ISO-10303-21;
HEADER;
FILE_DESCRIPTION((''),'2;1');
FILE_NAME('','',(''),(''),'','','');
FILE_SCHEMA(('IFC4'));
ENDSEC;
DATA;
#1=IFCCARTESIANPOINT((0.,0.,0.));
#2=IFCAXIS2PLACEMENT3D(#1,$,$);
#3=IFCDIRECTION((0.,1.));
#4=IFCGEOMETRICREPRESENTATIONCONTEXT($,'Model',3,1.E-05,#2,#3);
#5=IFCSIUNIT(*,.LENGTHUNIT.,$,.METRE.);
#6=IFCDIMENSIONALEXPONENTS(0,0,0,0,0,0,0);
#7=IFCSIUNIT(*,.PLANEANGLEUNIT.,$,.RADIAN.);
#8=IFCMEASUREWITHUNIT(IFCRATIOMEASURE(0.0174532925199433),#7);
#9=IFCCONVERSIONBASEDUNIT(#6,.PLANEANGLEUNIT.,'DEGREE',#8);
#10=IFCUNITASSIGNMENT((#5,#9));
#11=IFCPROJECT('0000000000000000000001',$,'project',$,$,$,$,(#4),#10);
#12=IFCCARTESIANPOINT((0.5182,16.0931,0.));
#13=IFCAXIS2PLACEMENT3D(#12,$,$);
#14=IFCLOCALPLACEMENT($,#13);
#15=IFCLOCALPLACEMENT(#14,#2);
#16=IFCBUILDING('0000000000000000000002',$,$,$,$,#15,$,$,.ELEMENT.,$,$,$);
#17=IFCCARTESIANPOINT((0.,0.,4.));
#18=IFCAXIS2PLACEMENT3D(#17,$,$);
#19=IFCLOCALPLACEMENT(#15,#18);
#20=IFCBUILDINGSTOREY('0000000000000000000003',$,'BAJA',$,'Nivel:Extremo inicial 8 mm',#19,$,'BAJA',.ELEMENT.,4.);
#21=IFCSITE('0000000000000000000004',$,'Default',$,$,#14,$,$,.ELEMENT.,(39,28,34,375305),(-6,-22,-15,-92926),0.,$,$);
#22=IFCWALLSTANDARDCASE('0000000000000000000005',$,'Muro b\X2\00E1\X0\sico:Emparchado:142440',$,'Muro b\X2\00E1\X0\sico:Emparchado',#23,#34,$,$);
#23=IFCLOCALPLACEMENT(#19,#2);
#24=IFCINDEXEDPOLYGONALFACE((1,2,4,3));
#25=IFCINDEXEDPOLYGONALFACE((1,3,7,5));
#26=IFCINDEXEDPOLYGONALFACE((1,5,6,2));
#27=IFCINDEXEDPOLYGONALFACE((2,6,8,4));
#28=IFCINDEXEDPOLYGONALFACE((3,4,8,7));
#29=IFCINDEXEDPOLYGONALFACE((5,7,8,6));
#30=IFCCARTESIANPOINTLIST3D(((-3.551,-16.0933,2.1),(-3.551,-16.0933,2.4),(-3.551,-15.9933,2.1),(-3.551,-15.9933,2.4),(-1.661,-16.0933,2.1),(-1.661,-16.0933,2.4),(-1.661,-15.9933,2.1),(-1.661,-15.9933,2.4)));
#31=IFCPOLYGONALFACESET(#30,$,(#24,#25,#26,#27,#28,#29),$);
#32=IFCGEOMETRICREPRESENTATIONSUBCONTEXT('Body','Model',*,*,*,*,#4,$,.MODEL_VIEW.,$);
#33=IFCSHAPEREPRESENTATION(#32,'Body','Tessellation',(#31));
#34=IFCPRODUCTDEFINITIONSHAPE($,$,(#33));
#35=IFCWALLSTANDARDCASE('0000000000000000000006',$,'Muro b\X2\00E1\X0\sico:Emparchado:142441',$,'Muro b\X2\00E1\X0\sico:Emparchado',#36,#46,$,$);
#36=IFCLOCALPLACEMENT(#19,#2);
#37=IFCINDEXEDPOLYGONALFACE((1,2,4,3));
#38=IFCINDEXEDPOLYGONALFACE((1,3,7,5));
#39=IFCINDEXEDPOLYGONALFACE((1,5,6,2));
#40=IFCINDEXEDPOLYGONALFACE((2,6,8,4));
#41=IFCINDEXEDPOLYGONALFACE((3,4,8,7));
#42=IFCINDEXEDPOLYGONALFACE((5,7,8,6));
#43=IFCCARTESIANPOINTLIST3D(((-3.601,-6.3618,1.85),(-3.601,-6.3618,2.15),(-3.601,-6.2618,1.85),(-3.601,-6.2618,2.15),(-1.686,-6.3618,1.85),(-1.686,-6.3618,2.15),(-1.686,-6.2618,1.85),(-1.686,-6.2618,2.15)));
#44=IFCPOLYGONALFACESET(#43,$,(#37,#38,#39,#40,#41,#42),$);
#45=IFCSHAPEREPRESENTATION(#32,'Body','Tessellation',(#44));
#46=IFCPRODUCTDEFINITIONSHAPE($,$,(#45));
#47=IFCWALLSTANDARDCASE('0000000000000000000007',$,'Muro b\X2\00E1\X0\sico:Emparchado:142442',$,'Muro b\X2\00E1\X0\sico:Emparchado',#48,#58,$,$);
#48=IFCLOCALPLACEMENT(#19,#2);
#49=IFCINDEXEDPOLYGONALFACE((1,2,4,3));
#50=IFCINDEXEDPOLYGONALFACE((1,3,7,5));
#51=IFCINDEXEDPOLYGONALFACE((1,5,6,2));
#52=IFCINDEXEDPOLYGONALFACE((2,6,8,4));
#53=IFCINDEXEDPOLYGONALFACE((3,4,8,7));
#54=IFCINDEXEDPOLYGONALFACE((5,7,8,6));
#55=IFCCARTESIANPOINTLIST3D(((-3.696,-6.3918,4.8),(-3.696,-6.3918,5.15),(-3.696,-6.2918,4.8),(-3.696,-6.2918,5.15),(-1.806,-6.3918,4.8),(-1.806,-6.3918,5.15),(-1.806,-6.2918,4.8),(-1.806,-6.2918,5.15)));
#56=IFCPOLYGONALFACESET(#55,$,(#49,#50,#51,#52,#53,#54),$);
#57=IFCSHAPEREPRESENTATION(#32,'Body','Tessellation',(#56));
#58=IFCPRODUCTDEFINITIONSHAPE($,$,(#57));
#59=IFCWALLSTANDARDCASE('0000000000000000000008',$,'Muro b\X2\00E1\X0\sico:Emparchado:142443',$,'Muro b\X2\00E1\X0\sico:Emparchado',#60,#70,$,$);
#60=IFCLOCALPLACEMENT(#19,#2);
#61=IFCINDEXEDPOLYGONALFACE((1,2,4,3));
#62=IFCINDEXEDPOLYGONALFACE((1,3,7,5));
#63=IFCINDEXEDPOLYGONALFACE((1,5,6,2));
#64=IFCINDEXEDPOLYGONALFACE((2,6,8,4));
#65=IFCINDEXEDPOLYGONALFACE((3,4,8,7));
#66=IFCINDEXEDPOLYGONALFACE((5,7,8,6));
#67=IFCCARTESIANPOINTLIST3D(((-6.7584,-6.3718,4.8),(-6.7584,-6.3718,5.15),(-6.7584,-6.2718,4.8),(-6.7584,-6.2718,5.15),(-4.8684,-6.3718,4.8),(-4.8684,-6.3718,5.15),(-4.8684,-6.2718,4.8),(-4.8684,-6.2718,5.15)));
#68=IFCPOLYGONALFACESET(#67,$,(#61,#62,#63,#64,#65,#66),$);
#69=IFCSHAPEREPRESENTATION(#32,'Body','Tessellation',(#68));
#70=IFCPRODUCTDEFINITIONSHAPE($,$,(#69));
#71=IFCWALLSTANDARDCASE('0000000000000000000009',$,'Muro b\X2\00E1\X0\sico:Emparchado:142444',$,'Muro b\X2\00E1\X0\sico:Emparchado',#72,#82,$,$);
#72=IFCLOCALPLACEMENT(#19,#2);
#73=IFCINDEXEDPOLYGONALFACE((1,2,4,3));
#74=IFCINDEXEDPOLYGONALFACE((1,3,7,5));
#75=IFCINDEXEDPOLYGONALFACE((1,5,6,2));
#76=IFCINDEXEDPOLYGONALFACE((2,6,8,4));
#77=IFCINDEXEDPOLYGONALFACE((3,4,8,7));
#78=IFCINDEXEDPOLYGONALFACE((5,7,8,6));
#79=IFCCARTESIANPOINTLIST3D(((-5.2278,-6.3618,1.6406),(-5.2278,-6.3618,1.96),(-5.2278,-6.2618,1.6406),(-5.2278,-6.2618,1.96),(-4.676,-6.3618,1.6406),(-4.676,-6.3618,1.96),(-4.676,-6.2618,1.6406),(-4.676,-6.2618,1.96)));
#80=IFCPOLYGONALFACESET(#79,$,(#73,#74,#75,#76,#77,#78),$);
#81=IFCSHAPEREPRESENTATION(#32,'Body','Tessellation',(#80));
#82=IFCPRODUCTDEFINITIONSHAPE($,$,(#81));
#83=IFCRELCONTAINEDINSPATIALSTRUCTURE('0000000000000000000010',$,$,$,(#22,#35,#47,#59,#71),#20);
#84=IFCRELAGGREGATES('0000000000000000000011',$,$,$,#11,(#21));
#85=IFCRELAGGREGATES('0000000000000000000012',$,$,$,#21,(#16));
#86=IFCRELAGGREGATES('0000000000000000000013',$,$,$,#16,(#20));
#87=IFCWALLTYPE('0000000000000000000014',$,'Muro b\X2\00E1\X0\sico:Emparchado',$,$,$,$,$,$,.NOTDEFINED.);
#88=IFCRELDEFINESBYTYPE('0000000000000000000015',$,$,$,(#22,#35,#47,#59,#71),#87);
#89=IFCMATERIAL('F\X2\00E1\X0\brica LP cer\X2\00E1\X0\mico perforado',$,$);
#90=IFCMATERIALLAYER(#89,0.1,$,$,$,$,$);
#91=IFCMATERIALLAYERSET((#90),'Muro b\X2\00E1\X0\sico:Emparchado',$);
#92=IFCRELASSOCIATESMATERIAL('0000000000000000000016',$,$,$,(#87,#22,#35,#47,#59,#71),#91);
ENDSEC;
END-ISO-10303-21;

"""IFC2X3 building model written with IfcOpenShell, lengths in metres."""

from ifc_helpers import new_model, entity, si_unit, converted_unit, direction, frame, frame_2d, origin, place, context, subcontext, project, spatial, rectangle, extrude, material, layer, layer_set, layer_usage, type_object, element, save


model = new_model("IFC2X3")

# Units and contexts
model_context = context("Model", 3, precision=1e-05, world=origin(), true_north=direction((0.0, 1.0)))
body_context = subcontext(model_context, "Body", "Model", "MODEL_VIEW")
ifc_project = project(units=[si_unit("LENGTHUNIT", "METRE"), converted_unit("PLANEANGLEUNIT", "DEGREE", entity("IfcRatioMeasure", 0.0174532925199433), si_unit("PLANEANGLEUNIT", "RADIAN"), dimensions=[0, 0, 0, 0, 0, 0, 0])], contexts=[model_context])

# Site, building, storey
site_placement = place(None, frame((0.5182, 16.0931, 0.0)))
site = spatial("IfcSite", under=ifc_project, at=site_placement, Name="Default", CompositionType="ELEMENT", RefLatitude=(39, 28, 34, 375305), RefLongitude=(-6, -22, -15, -92926), RefElevation=0.0)
building_placement = place(site_placement, origin())
building = spatial("IfcBuilding", under=site, at=building_placement, CompositionType="ELEMENT")
storey_placement = place(building_placement, frame((0.0, 0.0, 4.0)))
storey = spatial("IfcBuildingStorey", under=building, at=storey_placement, Name="BAJA", ObjectType="Nivel:Extremo inicial 8 mm", LongName="BAJA", CompositionType="ELEMENT", Elevation=4.0)

# Shared definitions
ifc_material_1 = material(Name="Fábrica LP cerámico perforado")

# Walls
ifc_layer_1 = layer(ifc_material_1, 0.1)
ifc_layer_set_1 = layer_set([ifc_layer_1], Name="Muro básico:Emparchado")
wall_type_1 = type_object("IfcWallType", Name="Muro básico:Emparchado", PredefinedType="NOTDEFINED", material=ifc_layer_set_1)
ifc_layer_usage_1 = layer_usage(ifc_layer_set_1, "AXIS2", "NEGATIVE", 0.05)
wall_1_placement = place(storey_placement, frame((-3.551, -16.0433, 2.1)))
element("IfcWallStandardCase", 1, at=wall_1_placement, inside=storey, type_object=wall_type_1, material=ifc_layer_usage_1, Name="Muro básico:Emparchado:142440", ObjectType="Muro básico:Emparchado", context=body_context, shape_type="SweptSolid", body=[
    extrude(rectangle(XDim=1.89, YDim=0.1, at=frame_2d((0.945, 0.0), x_axis=(-1.0, 0.0))), origin(), (0.0, 0.0, 1.0), 0.3),
])
ifc_layer_usage_2 = layer_usage(ifc_layer_set_1, "AXIS2", "NEGATIVE", 0.05)
wall_2_placement = place(storey_placement, frame((-3.601, -6.3118, 1.85)))
element("IfcWallStandardCase", 2, at=wall_2_placement, inside=storey, type_object=wall_type_1, material=ifc_layer_usage_2, Name="Muro básico:Emparchado:142441", ObjectType="Muro básico:Emparchado", context=body_context, shape_type="SweptSolid", body=[
    extrude(rectangle(XDim=1.9151, YDim=0.1, at=frame_2d((0.9575, 0.0), x_axis=(-1.0, 0.0))), origin(), (0.0, 0.0, 1.0), 0.3),
])
ifc_layer_usage_3 = layer_usage(ifc_layer_set_1, "AXIS2", "NEGATIVE", 0.05)
wall_3_placement = place(storey_placement, frame((-3.696, -6.3418, 4.8)))
element("IfcWallStandardCase", 3, at=wall_3_placement, inside=storey, type_object=wall_type_1, material=ifc_layer_usage_3, Name="Muro básico:Emparchado:142442", ObjectType="Muro básico:Emparchado", context=body_context, shape_type="SweptSolid", body=[
    extrude(rectangle(XDim=1.89, YDim=0.1, at=frame_2d((0.945, 0.0), x_axis=(-1.0, 0.0))), origin(), (0.0, 0.0, 1.0), 0.35),
])
ifc_layer_usage_4 = layer_usage(ifc_layer_set_1, "AXIS2", "NEGATIVE", 0.05)
wall_4_placement = place(storey_placement, frame((-6.7584, -6.3218, 4.8)))
element("IfcWallStandardCase", 4, at=wall_4_placement, inside=storey, type_object=wall_type_1, material=ifc_layer_usage_4, Name="Muro básico:Emparchado:142443", ObjectType="Muro básico:Emparchado", context=body_context, shape_type="SweptSolid", body=[
    extrude(rectangle(XDim=1.89, YDim=0.1, at=frame_2d((0.945, 0.0), x_axis=(-1.0, 0.0))), origin(), (0.0, 0.0, 1.0), 0.35),
])
ifc_layer_usage_5 = layer_usage(ifc_layer_set_1, "AXIS2", "NEGATIVE", 0.05)
wall_5_placement = place(storey_placement, frame((-5.2278, -6.3118, 1.6406)))
element("IfcWallStandardCase", 5, at=wall_5_placement, inside=storey, type_object=wall_type_1, material=ifc_layer_usage_5, Name="Muro básico:Emparchado:142444", ObjectType="Muro básico:Emparchado", context=body_context, shape_type="SweptSolid", body=[
    extrude(rectangle(XDim=0.5519, YDim=0.1, at=frame_2d((0.2759, 0.0), x_axis=(-1.0, 0.0))), origin(), (0.0, 0.0, 1.0), 0.3194),
])

save(model, "model.ifc")
